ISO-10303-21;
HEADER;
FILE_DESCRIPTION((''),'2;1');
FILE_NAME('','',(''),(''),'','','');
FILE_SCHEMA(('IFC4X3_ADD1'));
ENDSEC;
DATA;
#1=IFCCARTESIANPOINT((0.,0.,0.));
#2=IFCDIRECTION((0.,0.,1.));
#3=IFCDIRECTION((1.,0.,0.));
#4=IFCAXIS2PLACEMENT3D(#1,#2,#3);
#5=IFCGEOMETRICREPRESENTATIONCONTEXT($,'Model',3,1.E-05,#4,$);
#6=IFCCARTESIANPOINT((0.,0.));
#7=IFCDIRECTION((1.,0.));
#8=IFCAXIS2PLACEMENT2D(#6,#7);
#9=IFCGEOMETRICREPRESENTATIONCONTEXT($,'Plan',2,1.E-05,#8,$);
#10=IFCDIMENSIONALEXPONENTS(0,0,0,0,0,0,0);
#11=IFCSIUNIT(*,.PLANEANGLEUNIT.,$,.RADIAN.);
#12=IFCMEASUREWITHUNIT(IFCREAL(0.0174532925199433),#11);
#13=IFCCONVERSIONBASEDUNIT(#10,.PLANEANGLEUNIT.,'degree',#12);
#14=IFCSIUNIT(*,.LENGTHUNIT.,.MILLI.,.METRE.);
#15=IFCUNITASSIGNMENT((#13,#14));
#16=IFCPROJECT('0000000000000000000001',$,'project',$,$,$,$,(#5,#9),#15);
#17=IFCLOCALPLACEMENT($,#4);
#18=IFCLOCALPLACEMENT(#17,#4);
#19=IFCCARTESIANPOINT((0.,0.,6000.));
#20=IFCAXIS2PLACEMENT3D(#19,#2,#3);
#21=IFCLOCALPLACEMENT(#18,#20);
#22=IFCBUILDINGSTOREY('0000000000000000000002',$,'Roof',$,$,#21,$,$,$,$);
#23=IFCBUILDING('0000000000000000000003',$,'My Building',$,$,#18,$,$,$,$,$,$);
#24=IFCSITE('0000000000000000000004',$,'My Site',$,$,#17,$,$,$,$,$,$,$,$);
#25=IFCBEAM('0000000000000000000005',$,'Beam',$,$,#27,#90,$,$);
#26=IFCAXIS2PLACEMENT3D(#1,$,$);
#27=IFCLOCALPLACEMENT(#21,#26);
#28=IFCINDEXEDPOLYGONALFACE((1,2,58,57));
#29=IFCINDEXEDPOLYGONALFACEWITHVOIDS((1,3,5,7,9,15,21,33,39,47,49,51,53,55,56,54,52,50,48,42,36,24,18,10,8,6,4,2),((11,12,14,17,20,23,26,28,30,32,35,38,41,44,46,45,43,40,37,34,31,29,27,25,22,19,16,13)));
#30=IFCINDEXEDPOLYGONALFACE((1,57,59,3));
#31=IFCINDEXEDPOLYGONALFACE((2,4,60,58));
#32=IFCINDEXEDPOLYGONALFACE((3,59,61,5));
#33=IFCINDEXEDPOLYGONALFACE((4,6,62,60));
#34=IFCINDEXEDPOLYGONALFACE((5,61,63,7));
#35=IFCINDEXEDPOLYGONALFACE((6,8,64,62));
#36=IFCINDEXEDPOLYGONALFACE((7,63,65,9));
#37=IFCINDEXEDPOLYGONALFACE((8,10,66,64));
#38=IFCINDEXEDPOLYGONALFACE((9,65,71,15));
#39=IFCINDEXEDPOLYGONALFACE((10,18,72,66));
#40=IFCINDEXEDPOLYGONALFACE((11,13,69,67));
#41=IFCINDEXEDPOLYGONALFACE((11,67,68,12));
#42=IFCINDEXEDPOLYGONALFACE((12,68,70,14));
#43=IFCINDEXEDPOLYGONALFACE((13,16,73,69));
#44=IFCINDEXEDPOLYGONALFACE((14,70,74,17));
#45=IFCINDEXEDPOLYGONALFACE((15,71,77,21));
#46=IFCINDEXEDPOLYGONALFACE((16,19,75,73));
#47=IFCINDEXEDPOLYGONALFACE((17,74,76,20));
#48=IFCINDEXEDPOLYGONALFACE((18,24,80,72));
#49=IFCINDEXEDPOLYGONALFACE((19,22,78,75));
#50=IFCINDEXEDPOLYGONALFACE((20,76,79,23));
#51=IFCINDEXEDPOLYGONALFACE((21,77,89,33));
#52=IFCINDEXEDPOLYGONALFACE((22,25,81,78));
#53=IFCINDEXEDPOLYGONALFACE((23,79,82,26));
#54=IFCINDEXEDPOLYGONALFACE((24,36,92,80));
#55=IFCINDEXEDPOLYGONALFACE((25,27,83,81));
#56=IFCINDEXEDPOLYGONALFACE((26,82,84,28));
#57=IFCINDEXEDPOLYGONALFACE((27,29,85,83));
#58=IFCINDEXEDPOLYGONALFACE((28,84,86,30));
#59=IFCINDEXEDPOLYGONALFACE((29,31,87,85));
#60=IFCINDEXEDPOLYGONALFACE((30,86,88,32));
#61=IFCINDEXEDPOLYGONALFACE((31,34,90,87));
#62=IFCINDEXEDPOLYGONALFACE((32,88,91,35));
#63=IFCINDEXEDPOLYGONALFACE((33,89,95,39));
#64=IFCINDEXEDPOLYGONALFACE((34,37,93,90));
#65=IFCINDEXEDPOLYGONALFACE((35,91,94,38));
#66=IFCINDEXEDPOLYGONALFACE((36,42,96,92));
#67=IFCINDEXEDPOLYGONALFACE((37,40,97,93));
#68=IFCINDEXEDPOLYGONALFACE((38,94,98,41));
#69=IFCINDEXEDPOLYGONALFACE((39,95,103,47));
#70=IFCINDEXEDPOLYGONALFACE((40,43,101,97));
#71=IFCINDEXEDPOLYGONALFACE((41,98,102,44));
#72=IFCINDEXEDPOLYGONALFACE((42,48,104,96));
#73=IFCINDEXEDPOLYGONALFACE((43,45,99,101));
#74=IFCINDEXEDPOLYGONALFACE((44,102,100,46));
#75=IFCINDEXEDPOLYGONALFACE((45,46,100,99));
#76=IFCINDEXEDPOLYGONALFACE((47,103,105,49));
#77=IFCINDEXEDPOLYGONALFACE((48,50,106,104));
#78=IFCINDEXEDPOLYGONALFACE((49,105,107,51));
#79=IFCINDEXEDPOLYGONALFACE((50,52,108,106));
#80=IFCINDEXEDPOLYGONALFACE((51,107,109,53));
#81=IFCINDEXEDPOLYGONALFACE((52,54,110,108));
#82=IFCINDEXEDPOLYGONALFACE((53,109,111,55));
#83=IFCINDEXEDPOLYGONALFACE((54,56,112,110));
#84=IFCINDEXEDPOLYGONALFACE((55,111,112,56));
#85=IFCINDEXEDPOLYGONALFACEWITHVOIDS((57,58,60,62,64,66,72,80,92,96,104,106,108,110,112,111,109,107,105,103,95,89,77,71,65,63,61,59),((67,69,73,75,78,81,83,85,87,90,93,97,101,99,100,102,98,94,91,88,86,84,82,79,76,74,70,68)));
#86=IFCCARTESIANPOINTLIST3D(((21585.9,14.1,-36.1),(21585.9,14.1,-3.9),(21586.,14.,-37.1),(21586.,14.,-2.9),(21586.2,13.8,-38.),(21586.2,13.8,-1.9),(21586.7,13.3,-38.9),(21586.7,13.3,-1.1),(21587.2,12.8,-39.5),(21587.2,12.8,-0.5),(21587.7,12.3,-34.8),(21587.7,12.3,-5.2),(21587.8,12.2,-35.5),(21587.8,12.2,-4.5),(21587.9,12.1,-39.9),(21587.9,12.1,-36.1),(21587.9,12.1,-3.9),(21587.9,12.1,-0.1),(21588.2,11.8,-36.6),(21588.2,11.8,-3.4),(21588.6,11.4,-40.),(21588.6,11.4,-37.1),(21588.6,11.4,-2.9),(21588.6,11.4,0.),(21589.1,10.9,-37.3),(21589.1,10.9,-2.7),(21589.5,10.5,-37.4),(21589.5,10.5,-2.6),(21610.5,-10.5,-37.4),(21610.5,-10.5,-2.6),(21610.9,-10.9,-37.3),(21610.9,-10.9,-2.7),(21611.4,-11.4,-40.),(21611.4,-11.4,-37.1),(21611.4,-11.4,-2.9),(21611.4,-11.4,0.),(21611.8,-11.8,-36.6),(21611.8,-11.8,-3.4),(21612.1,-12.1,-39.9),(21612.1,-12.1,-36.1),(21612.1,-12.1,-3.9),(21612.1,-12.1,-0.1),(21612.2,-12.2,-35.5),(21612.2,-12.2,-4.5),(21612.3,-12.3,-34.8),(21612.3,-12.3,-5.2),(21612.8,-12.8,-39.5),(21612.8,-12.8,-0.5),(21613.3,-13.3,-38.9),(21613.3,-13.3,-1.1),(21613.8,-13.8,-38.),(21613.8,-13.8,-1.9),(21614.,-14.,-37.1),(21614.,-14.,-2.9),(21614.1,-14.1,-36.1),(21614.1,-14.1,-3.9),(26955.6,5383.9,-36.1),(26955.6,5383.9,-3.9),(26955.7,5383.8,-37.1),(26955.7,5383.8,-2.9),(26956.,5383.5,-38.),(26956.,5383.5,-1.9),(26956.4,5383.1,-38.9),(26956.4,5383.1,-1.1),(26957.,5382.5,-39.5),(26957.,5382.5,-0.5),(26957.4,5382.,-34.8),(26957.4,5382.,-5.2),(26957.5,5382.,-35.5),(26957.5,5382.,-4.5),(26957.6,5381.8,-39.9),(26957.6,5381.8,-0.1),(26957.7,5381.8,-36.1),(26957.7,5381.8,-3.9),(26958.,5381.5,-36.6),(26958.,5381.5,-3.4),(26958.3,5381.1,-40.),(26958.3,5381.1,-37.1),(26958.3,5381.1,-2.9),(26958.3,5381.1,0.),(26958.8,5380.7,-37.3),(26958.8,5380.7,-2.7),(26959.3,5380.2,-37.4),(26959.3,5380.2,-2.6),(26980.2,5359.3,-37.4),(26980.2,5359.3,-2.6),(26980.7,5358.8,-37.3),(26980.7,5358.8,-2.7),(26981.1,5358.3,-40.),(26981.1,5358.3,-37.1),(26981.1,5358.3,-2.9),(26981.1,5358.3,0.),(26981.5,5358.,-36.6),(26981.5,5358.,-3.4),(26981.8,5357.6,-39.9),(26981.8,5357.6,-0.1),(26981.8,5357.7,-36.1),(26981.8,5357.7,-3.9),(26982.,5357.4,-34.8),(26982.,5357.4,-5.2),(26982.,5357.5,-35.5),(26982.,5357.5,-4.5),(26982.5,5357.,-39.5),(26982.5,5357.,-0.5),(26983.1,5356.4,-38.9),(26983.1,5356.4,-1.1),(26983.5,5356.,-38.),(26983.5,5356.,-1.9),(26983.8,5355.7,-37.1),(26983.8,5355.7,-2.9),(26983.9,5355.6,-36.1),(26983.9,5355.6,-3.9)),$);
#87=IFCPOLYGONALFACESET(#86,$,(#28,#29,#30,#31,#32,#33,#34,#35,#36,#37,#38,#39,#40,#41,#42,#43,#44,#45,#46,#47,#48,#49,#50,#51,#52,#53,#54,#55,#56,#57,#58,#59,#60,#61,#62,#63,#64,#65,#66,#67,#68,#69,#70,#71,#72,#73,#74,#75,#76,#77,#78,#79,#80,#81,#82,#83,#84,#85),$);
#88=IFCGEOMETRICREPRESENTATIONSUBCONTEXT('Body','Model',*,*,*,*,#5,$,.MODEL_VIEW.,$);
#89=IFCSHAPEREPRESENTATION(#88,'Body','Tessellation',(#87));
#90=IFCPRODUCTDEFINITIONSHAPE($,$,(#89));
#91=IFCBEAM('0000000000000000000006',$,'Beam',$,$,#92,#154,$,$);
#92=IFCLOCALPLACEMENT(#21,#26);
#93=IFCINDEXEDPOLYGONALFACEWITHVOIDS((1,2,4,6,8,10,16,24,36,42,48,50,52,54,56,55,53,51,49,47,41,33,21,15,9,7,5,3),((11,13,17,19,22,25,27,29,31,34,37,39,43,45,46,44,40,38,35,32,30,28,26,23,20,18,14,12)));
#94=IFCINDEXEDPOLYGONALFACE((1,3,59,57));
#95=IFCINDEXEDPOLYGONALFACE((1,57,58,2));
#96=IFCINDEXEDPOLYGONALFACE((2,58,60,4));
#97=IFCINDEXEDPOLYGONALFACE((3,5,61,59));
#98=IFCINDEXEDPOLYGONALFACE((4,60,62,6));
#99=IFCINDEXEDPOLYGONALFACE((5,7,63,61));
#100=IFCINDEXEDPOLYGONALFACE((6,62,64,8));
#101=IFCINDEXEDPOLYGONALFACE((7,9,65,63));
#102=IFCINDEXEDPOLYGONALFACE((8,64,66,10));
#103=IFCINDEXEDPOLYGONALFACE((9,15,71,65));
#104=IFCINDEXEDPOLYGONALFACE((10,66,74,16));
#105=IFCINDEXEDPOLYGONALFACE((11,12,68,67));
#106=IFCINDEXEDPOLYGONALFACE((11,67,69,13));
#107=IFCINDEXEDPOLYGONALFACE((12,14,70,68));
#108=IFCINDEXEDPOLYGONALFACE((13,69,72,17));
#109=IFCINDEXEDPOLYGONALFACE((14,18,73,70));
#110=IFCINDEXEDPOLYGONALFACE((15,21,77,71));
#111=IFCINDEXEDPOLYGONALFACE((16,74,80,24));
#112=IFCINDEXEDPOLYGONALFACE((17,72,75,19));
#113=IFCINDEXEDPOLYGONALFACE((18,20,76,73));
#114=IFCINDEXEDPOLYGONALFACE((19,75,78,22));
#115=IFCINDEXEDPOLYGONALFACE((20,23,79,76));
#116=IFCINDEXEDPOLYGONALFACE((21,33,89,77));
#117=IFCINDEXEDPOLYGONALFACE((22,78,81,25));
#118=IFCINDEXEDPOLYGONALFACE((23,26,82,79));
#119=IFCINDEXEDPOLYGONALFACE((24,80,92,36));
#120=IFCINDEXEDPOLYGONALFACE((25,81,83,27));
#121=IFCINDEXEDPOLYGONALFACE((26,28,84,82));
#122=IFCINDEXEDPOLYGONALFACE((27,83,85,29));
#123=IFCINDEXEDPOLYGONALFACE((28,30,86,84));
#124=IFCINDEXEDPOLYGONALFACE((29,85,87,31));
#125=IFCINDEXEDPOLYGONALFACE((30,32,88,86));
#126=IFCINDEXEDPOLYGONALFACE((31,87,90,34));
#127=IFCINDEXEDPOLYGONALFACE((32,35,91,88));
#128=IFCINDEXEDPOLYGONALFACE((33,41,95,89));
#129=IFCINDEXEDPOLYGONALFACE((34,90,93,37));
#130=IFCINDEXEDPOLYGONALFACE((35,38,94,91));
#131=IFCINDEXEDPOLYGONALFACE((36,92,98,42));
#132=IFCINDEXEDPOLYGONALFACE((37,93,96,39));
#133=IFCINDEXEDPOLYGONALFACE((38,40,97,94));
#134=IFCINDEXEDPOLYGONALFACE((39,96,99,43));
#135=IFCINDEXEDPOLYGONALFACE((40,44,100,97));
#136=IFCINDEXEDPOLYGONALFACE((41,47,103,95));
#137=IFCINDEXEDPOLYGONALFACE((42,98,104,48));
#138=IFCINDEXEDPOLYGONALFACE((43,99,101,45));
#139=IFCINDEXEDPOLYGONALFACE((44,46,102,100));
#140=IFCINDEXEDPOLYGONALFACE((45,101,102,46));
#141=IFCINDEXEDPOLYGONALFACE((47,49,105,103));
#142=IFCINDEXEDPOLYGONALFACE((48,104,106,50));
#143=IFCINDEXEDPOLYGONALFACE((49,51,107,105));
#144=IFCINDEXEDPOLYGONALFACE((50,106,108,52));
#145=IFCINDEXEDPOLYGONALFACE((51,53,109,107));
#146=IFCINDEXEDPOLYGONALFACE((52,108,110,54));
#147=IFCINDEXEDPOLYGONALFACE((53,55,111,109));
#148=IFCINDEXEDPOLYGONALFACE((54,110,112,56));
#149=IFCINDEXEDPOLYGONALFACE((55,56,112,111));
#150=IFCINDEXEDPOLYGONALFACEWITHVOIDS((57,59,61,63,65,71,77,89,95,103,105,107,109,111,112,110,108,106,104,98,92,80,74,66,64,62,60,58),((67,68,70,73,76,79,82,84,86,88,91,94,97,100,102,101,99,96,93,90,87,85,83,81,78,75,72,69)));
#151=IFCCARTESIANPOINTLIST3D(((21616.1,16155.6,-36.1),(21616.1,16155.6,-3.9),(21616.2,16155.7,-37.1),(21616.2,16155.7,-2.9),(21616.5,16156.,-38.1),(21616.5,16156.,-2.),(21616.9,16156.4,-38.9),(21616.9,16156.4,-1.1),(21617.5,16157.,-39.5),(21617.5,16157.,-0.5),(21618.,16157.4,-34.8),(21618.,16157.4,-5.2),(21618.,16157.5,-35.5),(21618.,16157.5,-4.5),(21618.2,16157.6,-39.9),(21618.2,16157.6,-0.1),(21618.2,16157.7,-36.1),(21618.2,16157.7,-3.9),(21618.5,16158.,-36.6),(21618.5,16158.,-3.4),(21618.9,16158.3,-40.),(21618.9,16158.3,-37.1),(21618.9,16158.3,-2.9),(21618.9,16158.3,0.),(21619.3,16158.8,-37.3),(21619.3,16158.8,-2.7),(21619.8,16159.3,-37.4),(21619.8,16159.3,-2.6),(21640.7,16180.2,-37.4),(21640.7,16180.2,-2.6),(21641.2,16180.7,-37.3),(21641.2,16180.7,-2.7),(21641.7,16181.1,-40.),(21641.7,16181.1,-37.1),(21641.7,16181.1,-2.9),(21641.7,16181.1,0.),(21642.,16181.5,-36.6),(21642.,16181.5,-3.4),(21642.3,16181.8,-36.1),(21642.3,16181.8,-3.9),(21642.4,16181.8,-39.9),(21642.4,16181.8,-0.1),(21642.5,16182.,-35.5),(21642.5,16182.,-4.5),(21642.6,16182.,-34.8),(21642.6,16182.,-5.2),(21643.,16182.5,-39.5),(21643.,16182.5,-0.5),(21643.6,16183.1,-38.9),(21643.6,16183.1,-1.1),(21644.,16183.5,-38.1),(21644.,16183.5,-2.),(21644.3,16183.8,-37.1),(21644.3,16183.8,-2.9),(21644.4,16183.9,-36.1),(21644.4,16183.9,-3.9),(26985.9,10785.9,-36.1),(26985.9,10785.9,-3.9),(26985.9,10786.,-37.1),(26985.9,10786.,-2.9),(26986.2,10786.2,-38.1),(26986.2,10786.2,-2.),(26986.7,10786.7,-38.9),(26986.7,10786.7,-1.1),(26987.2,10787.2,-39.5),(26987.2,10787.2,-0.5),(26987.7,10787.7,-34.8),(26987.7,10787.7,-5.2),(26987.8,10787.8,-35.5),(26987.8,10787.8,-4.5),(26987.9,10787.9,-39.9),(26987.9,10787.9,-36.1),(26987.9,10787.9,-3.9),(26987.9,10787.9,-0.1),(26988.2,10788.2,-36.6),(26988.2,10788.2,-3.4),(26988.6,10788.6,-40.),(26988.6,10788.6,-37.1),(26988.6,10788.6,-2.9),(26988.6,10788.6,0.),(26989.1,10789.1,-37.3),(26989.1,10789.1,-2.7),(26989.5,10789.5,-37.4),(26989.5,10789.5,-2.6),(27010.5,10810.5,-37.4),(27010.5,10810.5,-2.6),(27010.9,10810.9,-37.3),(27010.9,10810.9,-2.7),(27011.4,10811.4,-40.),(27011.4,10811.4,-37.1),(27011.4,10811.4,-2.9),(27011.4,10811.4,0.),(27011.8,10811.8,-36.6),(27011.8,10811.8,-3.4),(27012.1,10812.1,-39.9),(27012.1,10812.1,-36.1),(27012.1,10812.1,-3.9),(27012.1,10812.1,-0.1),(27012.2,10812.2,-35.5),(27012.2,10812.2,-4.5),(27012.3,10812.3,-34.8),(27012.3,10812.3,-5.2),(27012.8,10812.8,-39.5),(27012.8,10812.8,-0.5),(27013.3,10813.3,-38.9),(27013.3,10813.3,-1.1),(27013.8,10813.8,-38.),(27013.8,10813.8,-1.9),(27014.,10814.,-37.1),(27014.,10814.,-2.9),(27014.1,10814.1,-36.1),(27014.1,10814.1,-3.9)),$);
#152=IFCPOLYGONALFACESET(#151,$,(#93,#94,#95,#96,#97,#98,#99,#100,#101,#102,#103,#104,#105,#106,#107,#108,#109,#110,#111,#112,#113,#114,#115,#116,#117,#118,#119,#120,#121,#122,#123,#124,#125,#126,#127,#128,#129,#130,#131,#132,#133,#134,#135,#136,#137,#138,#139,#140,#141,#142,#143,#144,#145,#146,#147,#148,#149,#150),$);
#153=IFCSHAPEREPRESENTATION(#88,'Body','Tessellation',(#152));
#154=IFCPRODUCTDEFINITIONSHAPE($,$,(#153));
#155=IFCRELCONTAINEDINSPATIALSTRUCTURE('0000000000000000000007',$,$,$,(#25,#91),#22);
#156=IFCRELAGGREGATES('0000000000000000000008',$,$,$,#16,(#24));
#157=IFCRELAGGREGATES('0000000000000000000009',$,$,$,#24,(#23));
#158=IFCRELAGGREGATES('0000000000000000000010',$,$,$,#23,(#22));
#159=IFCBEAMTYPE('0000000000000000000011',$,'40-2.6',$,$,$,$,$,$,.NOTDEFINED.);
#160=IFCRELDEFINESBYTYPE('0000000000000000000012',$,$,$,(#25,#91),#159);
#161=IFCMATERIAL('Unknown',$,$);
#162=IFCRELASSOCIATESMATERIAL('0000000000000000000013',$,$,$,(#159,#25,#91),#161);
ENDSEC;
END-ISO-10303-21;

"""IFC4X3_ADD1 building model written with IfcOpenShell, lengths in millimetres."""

from ifc_helpers import new_model, entity, si_unit, converted_unit, frame, origin_with_axes, origin_2d_with_axis, place, context, subcontext, project, spatial, hollow_rectangle, extrude, material, material_profile, profile_set, profile_usage, type_object, element, save


model = new_model("IFC4X3_ADD1")

# Units and contexts
model_context = context("Model", 3, precision=1e-05, world=origin_with_axes())
plan_context = context("Plan", 2, precision=1e-05, world=origin_2d_with_axis())
body_context = subcontext(model_context, "Body", "Model", "MODEL_VIEW")
ifc_project = project(units=[converted_unit("PLANEANGLEUNIT", "degree", entity("IfcReal", 0.0174532925199433), si_unit("PLANEANGLEUNIT", "RADIAN"), dimensions=[0, 0, 0, 0, 0, 0, 0]), si_unit("LENGTHUNIT", "METRE", prefix="MILLI")], contexts=[model_context, plan_context])

# Site, building, storey
site_placement = place(None, origin_with_axes())
site = spatial("IfcSite", under=ifc_project, at=site_placement, Name="My Site")
building_placement = place(site_placement, origin_with_axes())
building = spatial("IfcBuilding", under=site, at=building_placement, Name="My Building")
storey_placement = place(building_placement, frame((0.0, 0.0, 6000.0), z_axis=(0.0, 0.0, 1.0), x_axis=(1.0, 0.0, 0.0)))
storey = spatial("IfcBuildingStorey", under=building, at=storey_placement, Name="Roof")

# Beams
ifc_material = material(Name="Unknown")
ifc_material_profile_1 = material_profile(ifc_material, hollow_rectangle(XDim=40.0, YDim=40.0, WallThickness=2.6, InnerFilletRadius=2.6, OuterFilletRadius=3.9))
ifc_profile_set_1 = profile_set([ifc_material_profile_1])
beam_type_1 = type_object("IfcBeamType", Name="40-2.6", PredefinedType="NOTDEFINED", material=ifc_profile_set_1)
ifc_profile_usage_1 = profile_usage(ifc_profile_set_1, cardinal=8)
beam_1_placement = place(storey_placement, frame((21600.0, 0.0, 0.0), z_axis=(0.707107, 0.707107, 0.0), x_axis=(-0.707107, 0.707107, 0.0)))
element("IfcBeam", 1, at=beam_1_placement, inside=storey, type_object=beam_type_1, material=ifc_profile_usage_1, Name="Beam", context=body_context, shape_type="SweptSolid", body=[
    extrude(hollow_rectangle(XDim=40.0, YDim=40.0, WallThickness=2.6, InnerFilletRadius=2.6, OuterFilletRadius=3.9), frame((0.0, -20.0, 0.0), z_axis=(0.0, 0.0, 1.0), x_axis=(1.0, 0.0, 0.0)), (0.0, 0.0, 1.0), 7594.0),
])
ifc_profile_usage_2 = profile_usage(ifc_profile_set_1, cardinal=8)
beam_2_placement = place(storey_placement, frame((27000.0, 10800.0, 0.0), z_axis=(-0.707107, 0.707107, 0.0), x_axis=(-0.707107, -0.707107, 0.0)))
element("IfcBeam", 2, at=beam_2_placement, inside=storey, type_object=beam_type_1, material=ifc_profile_usage_2, Name="Beam", context=body_context, shape_type="SweptSolid", body=[
    extrude(hollow_rectangle(XDim=40.0, YDim=40.0, WallThickness=2.6, InnerFilletRadius=2.6, OuterFilletRadius=3.9), frame((0.0, -20.0, 0.0), z_axis=(0.0, 0.0, 1.0), x_axis=(1.0, 0.0, 0.0)), (0.0, 0.0, 1.0), 7594.0),
])

save(model, "model.ifc")
